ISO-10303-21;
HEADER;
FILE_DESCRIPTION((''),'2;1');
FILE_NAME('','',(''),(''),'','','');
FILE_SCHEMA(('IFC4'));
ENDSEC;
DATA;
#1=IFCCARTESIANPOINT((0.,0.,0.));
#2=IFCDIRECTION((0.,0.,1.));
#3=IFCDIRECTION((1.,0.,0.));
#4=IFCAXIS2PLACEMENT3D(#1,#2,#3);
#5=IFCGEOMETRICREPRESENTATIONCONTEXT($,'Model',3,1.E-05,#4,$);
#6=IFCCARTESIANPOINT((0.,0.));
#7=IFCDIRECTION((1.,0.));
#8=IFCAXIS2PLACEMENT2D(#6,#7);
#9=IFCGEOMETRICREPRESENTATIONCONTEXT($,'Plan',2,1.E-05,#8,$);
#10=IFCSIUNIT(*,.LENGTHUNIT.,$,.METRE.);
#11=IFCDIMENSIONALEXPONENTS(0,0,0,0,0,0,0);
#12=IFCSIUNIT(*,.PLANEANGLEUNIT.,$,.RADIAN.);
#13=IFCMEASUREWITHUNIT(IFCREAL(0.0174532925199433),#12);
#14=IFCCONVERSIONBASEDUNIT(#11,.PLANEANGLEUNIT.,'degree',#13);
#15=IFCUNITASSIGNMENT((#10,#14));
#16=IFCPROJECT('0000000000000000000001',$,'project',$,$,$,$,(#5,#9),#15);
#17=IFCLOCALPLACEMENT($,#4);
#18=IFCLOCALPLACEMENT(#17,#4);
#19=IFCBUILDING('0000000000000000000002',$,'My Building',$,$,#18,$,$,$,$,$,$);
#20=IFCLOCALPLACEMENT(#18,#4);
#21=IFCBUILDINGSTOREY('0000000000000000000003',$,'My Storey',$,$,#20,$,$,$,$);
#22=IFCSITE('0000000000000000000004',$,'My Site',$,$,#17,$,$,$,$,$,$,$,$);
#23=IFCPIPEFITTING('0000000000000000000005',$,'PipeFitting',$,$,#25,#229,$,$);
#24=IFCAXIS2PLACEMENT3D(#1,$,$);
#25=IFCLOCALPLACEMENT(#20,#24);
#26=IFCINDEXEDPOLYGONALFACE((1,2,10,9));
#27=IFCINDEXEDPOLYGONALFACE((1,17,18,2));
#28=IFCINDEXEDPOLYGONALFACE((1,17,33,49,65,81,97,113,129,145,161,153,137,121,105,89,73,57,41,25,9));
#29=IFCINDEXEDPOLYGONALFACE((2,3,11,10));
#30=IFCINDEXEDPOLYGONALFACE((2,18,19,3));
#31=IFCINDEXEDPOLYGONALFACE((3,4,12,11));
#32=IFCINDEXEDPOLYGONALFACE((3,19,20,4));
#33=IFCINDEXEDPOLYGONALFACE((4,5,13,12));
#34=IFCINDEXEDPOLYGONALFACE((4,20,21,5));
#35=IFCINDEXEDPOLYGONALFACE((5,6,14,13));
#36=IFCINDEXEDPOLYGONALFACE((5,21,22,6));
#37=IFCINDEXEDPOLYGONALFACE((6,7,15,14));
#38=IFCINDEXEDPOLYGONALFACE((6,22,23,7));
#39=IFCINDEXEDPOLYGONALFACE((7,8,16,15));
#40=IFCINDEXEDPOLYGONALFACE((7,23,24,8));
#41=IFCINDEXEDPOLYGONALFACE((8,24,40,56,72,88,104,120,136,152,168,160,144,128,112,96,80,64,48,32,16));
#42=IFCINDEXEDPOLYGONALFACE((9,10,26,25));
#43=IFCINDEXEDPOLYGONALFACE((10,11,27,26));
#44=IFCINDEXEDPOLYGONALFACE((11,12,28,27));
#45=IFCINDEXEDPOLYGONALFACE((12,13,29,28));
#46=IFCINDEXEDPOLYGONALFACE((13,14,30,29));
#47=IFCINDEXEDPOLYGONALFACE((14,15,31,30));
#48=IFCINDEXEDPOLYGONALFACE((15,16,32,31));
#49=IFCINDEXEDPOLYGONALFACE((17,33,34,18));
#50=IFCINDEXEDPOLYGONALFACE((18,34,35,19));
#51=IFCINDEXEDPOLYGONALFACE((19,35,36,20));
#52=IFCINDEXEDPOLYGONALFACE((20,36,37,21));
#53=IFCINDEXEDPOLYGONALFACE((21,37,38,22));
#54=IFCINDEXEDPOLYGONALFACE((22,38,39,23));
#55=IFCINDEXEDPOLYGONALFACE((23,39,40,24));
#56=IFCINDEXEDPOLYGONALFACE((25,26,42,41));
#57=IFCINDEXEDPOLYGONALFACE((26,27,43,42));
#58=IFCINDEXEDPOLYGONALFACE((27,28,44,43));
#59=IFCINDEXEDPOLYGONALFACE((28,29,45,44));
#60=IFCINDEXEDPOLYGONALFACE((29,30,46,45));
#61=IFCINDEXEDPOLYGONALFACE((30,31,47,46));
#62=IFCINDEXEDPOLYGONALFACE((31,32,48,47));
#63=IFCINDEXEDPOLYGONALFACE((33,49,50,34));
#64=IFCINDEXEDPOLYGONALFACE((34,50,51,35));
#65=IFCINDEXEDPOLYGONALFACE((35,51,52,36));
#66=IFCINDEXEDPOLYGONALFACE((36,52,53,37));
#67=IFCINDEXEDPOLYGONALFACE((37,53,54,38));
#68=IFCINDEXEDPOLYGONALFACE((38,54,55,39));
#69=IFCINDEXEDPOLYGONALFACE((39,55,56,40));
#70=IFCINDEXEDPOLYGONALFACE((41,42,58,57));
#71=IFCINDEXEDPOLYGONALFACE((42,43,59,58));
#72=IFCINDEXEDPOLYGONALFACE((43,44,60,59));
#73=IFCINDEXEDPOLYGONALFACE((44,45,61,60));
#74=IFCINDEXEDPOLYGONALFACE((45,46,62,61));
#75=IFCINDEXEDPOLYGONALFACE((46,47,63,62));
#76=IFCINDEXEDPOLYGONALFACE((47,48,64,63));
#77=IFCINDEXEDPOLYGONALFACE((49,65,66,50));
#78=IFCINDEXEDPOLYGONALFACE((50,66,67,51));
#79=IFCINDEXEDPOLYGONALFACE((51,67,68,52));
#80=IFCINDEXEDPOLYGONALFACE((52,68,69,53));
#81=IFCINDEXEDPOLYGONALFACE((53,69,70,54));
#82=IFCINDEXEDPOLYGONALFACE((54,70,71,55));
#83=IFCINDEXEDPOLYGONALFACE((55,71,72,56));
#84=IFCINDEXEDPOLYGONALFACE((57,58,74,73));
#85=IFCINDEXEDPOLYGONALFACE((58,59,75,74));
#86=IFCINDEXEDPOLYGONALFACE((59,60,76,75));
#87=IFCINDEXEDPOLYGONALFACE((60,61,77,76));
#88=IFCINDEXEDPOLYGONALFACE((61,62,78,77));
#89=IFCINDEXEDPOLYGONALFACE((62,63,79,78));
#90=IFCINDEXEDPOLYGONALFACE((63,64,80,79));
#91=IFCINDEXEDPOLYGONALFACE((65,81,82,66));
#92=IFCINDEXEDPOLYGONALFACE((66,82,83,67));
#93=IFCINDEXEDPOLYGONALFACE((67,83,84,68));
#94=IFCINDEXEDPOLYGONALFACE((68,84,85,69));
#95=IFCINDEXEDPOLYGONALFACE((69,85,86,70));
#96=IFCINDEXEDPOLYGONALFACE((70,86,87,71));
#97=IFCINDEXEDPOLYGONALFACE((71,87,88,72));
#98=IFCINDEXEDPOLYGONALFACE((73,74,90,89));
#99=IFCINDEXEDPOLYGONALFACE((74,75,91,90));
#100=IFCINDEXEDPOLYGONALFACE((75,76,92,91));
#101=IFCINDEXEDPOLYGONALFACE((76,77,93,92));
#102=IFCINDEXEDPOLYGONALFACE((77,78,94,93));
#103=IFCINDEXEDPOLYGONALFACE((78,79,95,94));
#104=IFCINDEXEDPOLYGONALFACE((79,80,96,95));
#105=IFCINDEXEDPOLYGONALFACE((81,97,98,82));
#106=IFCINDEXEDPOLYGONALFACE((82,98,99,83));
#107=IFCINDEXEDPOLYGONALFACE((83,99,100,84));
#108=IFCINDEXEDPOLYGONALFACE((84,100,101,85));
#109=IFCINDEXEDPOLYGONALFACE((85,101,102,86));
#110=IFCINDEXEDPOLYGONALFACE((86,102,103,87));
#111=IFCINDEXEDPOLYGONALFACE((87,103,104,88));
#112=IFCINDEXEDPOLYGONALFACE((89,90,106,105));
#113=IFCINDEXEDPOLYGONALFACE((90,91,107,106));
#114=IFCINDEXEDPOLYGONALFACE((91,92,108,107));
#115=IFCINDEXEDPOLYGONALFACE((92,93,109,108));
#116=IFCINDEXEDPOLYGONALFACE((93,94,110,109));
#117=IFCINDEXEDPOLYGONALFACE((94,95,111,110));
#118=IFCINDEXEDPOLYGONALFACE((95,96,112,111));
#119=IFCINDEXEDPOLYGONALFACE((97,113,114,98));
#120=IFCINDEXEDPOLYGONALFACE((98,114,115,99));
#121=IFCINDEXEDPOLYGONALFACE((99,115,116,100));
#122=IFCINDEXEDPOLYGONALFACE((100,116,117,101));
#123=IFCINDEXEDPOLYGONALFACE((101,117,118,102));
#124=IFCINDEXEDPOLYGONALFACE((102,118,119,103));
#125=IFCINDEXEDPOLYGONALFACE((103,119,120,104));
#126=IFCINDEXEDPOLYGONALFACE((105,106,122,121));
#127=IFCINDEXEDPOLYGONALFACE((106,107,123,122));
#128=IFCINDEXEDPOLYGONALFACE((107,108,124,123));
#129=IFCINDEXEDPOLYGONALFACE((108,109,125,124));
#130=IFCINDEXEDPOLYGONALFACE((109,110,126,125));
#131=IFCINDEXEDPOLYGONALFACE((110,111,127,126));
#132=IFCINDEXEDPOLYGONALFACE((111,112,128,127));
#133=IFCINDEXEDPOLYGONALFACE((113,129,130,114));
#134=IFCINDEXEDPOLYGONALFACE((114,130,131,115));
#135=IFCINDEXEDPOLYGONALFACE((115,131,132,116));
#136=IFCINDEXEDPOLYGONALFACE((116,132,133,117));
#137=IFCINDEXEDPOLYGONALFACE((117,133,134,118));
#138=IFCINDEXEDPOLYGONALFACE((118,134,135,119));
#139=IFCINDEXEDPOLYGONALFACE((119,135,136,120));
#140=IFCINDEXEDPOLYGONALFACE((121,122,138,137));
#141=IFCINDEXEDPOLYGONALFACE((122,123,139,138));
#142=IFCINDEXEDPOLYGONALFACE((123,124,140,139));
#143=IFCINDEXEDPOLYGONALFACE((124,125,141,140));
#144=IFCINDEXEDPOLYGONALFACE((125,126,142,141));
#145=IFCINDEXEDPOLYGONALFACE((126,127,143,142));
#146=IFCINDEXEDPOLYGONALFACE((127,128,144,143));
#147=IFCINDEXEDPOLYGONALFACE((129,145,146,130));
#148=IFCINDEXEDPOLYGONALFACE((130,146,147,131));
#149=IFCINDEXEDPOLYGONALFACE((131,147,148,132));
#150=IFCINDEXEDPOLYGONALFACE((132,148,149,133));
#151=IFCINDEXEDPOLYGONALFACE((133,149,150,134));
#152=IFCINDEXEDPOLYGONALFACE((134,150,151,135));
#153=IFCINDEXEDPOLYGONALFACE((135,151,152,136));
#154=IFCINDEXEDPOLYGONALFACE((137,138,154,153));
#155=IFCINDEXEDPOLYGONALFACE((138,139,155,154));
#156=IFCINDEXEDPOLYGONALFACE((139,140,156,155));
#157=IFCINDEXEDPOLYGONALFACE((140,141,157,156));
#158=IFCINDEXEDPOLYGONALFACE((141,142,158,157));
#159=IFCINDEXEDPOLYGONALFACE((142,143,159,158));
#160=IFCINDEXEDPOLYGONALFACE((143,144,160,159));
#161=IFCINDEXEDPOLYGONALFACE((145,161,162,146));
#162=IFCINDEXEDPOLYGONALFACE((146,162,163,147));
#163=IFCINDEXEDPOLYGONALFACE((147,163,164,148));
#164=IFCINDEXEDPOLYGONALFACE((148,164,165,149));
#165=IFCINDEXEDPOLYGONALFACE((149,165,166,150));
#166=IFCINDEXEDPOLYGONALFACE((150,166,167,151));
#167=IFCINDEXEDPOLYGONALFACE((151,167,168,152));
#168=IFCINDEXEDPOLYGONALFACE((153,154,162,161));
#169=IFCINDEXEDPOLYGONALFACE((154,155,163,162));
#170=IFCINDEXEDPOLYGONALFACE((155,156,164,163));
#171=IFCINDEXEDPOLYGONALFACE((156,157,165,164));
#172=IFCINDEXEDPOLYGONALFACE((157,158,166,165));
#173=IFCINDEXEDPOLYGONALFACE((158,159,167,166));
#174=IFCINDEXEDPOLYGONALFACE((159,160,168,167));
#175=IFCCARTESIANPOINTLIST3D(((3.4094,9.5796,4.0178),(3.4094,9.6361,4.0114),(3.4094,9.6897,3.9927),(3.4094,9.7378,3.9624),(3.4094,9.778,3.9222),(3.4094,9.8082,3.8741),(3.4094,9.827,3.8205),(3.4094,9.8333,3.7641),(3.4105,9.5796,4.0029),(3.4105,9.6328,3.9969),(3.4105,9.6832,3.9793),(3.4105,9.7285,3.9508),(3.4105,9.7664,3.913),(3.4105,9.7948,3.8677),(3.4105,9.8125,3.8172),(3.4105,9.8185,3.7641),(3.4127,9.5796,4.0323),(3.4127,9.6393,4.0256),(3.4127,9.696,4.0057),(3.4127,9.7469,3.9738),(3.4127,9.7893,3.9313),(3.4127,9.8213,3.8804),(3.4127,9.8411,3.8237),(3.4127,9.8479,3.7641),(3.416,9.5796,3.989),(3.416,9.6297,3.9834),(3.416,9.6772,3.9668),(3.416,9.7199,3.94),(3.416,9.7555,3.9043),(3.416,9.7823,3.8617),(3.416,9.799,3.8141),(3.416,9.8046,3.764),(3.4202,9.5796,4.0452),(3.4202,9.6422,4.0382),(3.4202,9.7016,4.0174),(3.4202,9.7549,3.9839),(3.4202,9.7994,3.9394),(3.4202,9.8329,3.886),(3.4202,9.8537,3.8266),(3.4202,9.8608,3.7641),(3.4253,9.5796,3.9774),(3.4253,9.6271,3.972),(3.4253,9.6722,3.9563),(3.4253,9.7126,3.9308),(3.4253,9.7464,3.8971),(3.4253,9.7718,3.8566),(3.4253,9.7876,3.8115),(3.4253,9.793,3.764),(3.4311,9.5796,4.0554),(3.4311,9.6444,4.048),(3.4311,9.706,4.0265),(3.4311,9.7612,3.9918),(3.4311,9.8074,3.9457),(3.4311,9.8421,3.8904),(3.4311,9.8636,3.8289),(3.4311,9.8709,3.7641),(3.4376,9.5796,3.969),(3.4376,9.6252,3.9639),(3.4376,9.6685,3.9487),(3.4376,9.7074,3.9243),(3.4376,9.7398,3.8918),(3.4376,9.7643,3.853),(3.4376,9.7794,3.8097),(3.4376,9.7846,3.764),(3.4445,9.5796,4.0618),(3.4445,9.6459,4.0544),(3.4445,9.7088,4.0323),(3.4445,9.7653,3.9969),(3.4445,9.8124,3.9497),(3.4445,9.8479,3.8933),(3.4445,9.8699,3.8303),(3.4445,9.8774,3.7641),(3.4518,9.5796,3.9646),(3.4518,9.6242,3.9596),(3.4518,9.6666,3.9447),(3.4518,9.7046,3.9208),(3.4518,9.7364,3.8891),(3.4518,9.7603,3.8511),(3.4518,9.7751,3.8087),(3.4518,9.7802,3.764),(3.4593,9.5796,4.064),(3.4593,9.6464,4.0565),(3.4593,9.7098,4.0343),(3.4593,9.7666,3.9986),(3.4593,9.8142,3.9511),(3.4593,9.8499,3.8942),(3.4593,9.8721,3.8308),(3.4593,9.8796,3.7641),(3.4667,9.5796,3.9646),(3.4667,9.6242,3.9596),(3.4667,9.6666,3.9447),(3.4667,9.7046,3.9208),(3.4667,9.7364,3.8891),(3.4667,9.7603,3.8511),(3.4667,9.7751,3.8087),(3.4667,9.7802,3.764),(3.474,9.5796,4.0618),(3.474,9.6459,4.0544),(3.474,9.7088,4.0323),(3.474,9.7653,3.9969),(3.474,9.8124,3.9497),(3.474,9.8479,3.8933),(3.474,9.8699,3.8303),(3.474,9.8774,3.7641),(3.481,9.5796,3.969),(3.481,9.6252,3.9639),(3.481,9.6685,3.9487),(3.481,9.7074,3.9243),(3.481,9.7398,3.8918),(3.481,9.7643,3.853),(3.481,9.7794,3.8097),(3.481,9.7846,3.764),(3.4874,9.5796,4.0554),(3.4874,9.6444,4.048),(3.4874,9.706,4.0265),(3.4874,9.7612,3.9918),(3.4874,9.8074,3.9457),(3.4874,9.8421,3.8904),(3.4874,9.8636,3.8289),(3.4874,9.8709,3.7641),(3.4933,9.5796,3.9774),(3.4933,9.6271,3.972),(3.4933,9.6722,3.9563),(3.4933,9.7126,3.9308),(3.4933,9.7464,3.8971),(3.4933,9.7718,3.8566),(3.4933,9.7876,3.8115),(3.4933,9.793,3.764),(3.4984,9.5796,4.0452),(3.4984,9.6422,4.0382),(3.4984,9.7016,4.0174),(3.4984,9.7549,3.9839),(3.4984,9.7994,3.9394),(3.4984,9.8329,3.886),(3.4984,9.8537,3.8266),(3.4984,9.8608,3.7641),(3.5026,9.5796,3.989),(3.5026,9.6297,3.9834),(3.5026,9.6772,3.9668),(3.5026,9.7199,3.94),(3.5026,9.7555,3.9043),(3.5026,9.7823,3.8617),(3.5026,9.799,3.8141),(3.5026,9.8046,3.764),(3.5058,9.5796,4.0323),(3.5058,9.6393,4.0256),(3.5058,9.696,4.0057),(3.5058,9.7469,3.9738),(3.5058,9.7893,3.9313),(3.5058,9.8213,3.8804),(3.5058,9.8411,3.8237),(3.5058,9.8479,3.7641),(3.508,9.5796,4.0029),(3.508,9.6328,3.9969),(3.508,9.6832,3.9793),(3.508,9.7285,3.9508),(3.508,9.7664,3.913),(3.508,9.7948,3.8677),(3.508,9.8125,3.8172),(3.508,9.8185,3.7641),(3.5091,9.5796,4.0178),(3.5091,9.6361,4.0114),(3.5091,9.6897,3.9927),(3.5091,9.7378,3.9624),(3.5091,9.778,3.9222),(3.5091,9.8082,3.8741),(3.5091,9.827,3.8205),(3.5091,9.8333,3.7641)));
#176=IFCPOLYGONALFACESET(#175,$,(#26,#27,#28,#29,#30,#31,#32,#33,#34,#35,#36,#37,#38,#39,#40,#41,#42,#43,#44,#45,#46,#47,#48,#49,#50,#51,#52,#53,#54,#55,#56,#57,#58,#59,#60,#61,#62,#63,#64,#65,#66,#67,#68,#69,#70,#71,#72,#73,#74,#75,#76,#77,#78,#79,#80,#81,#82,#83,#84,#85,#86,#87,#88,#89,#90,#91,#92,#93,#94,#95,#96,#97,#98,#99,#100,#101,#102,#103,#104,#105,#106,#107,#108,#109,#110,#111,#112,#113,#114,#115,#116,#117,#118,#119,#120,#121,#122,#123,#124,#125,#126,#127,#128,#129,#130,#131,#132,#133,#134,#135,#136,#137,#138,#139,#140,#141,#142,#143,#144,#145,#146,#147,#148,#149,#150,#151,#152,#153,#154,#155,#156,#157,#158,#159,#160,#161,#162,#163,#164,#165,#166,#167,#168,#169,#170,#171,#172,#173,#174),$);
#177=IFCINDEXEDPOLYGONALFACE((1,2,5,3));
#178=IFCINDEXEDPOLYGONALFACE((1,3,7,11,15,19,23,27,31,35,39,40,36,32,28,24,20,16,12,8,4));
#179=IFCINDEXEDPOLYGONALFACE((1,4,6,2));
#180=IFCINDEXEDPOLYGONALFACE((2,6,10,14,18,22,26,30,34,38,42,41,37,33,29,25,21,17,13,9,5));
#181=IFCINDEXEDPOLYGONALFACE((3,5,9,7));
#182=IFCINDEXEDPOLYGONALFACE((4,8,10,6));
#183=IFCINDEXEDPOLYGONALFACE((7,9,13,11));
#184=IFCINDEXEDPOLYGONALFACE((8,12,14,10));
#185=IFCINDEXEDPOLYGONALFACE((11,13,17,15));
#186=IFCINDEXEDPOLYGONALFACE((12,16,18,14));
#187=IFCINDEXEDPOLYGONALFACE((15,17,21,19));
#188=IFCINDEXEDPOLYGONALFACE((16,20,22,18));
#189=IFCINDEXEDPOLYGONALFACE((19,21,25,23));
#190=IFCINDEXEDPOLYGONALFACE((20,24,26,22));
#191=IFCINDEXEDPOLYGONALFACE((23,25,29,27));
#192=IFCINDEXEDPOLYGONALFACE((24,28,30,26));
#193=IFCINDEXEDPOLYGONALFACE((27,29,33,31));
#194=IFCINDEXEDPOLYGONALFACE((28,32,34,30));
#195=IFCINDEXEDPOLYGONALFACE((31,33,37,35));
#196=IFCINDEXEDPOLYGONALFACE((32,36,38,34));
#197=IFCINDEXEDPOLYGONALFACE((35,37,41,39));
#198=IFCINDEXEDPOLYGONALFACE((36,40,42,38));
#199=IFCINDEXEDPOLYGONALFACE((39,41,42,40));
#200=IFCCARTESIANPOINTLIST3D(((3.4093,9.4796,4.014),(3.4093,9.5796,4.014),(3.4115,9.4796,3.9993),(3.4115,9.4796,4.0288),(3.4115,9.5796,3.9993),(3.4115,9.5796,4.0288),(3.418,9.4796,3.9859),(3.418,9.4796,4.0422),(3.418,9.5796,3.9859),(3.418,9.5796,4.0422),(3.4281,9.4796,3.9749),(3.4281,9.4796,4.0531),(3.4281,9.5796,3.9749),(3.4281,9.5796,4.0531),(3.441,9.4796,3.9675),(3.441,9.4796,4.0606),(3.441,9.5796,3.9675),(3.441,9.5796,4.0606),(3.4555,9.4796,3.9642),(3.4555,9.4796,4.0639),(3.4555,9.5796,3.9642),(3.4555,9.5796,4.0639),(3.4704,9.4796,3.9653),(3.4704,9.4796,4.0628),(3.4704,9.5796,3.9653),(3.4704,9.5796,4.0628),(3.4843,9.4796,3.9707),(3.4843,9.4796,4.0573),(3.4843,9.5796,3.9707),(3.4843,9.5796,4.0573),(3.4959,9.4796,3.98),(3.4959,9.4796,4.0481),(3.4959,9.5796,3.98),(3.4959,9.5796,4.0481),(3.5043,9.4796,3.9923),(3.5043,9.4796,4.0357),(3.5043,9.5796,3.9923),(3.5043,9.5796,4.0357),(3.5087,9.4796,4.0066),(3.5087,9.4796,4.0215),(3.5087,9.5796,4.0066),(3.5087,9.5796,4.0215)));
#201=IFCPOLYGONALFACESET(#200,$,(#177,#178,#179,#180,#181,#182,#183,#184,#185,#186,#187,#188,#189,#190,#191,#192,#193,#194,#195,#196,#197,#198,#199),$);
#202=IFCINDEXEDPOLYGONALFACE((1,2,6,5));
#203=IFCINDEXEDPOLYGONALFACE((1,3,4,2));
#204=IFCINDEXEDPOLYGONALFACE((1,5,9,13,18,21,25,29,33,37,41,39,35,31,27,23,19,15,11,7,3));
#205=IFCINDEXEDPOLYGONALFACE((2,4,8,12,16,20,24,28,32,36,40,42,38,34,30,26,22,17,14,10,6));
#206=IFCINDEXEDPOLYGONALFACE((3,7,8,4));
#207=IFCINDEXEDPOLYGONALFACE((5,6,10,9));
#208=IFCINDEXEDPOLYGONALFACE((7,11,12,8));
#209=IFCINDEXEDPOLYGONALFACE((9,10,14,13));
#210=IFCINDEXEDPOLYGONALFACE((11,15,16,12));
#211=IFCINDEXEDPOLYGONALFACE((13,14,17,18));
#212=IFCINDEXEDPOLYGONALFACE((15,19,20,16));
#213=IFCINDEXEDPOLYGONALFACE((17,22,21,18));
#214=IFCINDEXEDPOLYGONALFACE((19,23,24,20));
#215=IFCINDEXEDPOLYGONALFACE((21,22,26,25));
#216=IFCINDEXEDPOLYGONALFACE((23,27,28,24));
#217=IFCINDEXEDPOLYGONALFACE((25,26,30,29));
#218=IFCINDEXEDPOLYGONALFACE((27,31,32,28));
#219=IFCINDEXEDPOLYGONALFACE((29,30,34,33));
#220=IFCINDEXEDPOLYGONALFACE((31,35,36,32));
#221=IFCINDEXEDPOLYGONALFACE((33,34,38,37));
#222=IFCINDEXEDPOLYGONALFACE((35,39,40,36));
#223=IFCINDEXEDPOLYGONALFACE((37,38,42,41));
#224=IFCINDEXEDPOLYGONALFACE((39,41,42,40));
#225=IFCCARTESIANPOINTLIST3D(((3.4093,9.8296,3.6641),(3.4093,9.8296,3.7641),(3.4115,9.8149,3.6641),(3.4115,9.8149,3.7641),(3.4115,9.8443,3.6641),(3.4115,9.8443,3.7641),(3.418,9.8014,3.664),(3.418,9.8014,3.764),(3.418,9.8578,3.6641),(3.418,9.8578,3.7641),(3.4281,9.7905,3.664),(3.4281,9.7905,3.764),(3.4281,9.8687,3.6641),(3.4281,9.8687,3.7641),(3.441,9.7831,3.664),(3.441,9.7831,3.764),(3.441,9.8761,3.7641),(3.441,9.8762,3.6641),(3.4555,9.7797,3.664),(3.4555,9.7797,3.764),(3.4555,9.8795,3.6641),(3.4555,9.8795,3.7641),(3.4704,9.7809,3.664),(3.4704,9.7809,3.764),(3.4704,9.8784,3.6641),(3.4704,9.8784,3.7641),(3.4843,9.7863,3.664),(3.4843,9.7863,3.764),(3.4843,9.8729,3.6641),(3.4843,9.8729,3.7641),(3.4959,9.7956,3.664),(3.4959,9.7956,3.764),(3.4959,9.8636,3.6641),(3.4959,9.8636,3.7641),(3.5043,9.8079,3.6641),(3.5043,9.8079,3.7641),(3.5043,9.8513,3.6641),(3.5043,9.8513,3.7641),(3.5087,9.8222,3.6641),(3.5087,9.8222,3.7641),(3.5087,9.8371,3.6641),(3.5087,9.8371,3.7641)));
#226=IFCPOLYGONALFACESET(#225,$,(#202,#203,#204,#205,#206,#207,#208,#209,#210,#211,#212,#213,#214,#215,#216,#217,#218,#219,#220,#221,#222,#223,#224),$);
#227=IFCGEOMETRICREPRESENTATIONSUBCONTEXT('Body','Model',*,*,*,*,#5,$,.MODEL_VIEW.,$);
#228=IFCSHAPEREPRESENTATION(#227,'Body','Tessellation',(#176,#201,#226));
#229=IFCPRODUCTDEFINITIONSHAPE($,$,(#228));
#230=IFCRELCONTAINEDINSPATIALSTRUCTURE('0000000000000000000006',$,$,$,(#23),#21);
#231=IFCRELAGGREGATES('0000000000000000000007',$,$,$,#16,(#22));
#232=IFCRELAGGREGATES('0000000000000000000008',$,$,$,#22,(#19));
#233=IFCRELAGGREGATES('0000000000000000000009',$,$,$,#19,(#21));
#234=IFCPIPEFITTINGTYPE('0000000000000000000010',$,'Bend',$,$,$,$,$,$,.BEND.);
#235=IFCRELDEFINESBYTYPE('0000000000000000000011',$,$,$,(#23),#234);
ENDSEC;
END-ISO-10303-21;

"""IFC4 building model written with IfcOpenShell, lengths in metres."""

from ifc_helpers import new_model, entity, si_unit, converted_unit, frame, origin_with_axes, origin_2d_with_axis, place, context, subcontext, project, spatial, circle, extrude, source, transform, mapped, type_object, type_shapes, element, save


model = new_model("IFC4")

# Units and contexts
model_context = context("Model", 3, precision=1e-05, world=origin_with_axes())
plan_context = context("Plan", 2, precision=1e-05, world=origin_2d_with_axis())
body_context = subcontext(model_context, "Body", "Model", "MODEL_VIEW")
ifc_project = project(units=[si_unit("LENGTHUNIT", "METRE"), converted_unit("PLANEANGLEUNIT", "degree", entity("IfcReal", 0.0174532925199433), si_unit("PLANEANGLEUNIT", "RADIAN"), dimensions=[0, 0, 0, 0, 0, 0, 0])], contexts=[model_context, plan_context])

# Site, building, storey
site_placement = place(None, origin_with_axes())
site = spatial("IfcSite", under=ifc_project, at=site_placement, Name="My Site")
building_placement = place(site_placement, origin_with_axes())
building = spatial("IfcBuilding", under=site, at=building_placement, Name="My Building")
storey_placement = place(building_placement, origin_with_axes())
storey = spatial("IfcBuildingStorey", under=building, at=storey_placement, Name="My Storey")

# Pipe fitting
pipe_fitting_type_1 = type_object("IfcPipeFittingType", Name="Bend", PredefinedType="BEND")
shared_shape_1 = source(origin_with_axes(), body_context, "Body", "SolidModel", [
    entity("IfcSweptDiskSolid", entity("IfcIndexedPolyCurve", entity("IfcCartesianPointList3D", [[0.0, 0.0, 0.1], [0.0, -0.0732, 0.2768], [0.0, -0.25, 0.35]]), [entity("IfcArcIndex", [1, 2, 3])]), 0.05),
    extrude(circle(Radius=0.05), origin_with_axes(), (0.0, 0.0, 1.0), 0.1),
    extrude(circle(Radius=0.05), frame((0.0, -0.25, 0.35), z_axis=(0.0, -1.0, 0.000038), x_axis=(1.0, 0.0, 0.0)), (0.0, 0.0, 1.0), 0.1),
])
type_shapes(pipe_fitting_type_1, [shared_shape_1])
for number, where, z_axis, x_axis, name in (
    (1, (3.4593, 9.4796, 4.014), (0.0, 1.0, 0.0), (-1.0, 0.0, 0.0), "PipeFitting"),
):
    element("IfcPipeFitting", number, at=place(storey_placement, frame(where, z_axis=z_axis, x_axis=x_axis)), inside=storey, type_object=pipe_fitting_type_1, Name=name, context=body_context, shape_type="MappedRepresentation", body=[
        mapped(shared_shape_1, transform((0.0, 0.0, 0.0), x_axis=(1.0, 0.0, 0.0), y_axis=(0.0, 1.0, 0.0), z_axis=(0.0, 0.0, 1.0), scale=1.0)),
    ])

save(model, "model.ifc")
